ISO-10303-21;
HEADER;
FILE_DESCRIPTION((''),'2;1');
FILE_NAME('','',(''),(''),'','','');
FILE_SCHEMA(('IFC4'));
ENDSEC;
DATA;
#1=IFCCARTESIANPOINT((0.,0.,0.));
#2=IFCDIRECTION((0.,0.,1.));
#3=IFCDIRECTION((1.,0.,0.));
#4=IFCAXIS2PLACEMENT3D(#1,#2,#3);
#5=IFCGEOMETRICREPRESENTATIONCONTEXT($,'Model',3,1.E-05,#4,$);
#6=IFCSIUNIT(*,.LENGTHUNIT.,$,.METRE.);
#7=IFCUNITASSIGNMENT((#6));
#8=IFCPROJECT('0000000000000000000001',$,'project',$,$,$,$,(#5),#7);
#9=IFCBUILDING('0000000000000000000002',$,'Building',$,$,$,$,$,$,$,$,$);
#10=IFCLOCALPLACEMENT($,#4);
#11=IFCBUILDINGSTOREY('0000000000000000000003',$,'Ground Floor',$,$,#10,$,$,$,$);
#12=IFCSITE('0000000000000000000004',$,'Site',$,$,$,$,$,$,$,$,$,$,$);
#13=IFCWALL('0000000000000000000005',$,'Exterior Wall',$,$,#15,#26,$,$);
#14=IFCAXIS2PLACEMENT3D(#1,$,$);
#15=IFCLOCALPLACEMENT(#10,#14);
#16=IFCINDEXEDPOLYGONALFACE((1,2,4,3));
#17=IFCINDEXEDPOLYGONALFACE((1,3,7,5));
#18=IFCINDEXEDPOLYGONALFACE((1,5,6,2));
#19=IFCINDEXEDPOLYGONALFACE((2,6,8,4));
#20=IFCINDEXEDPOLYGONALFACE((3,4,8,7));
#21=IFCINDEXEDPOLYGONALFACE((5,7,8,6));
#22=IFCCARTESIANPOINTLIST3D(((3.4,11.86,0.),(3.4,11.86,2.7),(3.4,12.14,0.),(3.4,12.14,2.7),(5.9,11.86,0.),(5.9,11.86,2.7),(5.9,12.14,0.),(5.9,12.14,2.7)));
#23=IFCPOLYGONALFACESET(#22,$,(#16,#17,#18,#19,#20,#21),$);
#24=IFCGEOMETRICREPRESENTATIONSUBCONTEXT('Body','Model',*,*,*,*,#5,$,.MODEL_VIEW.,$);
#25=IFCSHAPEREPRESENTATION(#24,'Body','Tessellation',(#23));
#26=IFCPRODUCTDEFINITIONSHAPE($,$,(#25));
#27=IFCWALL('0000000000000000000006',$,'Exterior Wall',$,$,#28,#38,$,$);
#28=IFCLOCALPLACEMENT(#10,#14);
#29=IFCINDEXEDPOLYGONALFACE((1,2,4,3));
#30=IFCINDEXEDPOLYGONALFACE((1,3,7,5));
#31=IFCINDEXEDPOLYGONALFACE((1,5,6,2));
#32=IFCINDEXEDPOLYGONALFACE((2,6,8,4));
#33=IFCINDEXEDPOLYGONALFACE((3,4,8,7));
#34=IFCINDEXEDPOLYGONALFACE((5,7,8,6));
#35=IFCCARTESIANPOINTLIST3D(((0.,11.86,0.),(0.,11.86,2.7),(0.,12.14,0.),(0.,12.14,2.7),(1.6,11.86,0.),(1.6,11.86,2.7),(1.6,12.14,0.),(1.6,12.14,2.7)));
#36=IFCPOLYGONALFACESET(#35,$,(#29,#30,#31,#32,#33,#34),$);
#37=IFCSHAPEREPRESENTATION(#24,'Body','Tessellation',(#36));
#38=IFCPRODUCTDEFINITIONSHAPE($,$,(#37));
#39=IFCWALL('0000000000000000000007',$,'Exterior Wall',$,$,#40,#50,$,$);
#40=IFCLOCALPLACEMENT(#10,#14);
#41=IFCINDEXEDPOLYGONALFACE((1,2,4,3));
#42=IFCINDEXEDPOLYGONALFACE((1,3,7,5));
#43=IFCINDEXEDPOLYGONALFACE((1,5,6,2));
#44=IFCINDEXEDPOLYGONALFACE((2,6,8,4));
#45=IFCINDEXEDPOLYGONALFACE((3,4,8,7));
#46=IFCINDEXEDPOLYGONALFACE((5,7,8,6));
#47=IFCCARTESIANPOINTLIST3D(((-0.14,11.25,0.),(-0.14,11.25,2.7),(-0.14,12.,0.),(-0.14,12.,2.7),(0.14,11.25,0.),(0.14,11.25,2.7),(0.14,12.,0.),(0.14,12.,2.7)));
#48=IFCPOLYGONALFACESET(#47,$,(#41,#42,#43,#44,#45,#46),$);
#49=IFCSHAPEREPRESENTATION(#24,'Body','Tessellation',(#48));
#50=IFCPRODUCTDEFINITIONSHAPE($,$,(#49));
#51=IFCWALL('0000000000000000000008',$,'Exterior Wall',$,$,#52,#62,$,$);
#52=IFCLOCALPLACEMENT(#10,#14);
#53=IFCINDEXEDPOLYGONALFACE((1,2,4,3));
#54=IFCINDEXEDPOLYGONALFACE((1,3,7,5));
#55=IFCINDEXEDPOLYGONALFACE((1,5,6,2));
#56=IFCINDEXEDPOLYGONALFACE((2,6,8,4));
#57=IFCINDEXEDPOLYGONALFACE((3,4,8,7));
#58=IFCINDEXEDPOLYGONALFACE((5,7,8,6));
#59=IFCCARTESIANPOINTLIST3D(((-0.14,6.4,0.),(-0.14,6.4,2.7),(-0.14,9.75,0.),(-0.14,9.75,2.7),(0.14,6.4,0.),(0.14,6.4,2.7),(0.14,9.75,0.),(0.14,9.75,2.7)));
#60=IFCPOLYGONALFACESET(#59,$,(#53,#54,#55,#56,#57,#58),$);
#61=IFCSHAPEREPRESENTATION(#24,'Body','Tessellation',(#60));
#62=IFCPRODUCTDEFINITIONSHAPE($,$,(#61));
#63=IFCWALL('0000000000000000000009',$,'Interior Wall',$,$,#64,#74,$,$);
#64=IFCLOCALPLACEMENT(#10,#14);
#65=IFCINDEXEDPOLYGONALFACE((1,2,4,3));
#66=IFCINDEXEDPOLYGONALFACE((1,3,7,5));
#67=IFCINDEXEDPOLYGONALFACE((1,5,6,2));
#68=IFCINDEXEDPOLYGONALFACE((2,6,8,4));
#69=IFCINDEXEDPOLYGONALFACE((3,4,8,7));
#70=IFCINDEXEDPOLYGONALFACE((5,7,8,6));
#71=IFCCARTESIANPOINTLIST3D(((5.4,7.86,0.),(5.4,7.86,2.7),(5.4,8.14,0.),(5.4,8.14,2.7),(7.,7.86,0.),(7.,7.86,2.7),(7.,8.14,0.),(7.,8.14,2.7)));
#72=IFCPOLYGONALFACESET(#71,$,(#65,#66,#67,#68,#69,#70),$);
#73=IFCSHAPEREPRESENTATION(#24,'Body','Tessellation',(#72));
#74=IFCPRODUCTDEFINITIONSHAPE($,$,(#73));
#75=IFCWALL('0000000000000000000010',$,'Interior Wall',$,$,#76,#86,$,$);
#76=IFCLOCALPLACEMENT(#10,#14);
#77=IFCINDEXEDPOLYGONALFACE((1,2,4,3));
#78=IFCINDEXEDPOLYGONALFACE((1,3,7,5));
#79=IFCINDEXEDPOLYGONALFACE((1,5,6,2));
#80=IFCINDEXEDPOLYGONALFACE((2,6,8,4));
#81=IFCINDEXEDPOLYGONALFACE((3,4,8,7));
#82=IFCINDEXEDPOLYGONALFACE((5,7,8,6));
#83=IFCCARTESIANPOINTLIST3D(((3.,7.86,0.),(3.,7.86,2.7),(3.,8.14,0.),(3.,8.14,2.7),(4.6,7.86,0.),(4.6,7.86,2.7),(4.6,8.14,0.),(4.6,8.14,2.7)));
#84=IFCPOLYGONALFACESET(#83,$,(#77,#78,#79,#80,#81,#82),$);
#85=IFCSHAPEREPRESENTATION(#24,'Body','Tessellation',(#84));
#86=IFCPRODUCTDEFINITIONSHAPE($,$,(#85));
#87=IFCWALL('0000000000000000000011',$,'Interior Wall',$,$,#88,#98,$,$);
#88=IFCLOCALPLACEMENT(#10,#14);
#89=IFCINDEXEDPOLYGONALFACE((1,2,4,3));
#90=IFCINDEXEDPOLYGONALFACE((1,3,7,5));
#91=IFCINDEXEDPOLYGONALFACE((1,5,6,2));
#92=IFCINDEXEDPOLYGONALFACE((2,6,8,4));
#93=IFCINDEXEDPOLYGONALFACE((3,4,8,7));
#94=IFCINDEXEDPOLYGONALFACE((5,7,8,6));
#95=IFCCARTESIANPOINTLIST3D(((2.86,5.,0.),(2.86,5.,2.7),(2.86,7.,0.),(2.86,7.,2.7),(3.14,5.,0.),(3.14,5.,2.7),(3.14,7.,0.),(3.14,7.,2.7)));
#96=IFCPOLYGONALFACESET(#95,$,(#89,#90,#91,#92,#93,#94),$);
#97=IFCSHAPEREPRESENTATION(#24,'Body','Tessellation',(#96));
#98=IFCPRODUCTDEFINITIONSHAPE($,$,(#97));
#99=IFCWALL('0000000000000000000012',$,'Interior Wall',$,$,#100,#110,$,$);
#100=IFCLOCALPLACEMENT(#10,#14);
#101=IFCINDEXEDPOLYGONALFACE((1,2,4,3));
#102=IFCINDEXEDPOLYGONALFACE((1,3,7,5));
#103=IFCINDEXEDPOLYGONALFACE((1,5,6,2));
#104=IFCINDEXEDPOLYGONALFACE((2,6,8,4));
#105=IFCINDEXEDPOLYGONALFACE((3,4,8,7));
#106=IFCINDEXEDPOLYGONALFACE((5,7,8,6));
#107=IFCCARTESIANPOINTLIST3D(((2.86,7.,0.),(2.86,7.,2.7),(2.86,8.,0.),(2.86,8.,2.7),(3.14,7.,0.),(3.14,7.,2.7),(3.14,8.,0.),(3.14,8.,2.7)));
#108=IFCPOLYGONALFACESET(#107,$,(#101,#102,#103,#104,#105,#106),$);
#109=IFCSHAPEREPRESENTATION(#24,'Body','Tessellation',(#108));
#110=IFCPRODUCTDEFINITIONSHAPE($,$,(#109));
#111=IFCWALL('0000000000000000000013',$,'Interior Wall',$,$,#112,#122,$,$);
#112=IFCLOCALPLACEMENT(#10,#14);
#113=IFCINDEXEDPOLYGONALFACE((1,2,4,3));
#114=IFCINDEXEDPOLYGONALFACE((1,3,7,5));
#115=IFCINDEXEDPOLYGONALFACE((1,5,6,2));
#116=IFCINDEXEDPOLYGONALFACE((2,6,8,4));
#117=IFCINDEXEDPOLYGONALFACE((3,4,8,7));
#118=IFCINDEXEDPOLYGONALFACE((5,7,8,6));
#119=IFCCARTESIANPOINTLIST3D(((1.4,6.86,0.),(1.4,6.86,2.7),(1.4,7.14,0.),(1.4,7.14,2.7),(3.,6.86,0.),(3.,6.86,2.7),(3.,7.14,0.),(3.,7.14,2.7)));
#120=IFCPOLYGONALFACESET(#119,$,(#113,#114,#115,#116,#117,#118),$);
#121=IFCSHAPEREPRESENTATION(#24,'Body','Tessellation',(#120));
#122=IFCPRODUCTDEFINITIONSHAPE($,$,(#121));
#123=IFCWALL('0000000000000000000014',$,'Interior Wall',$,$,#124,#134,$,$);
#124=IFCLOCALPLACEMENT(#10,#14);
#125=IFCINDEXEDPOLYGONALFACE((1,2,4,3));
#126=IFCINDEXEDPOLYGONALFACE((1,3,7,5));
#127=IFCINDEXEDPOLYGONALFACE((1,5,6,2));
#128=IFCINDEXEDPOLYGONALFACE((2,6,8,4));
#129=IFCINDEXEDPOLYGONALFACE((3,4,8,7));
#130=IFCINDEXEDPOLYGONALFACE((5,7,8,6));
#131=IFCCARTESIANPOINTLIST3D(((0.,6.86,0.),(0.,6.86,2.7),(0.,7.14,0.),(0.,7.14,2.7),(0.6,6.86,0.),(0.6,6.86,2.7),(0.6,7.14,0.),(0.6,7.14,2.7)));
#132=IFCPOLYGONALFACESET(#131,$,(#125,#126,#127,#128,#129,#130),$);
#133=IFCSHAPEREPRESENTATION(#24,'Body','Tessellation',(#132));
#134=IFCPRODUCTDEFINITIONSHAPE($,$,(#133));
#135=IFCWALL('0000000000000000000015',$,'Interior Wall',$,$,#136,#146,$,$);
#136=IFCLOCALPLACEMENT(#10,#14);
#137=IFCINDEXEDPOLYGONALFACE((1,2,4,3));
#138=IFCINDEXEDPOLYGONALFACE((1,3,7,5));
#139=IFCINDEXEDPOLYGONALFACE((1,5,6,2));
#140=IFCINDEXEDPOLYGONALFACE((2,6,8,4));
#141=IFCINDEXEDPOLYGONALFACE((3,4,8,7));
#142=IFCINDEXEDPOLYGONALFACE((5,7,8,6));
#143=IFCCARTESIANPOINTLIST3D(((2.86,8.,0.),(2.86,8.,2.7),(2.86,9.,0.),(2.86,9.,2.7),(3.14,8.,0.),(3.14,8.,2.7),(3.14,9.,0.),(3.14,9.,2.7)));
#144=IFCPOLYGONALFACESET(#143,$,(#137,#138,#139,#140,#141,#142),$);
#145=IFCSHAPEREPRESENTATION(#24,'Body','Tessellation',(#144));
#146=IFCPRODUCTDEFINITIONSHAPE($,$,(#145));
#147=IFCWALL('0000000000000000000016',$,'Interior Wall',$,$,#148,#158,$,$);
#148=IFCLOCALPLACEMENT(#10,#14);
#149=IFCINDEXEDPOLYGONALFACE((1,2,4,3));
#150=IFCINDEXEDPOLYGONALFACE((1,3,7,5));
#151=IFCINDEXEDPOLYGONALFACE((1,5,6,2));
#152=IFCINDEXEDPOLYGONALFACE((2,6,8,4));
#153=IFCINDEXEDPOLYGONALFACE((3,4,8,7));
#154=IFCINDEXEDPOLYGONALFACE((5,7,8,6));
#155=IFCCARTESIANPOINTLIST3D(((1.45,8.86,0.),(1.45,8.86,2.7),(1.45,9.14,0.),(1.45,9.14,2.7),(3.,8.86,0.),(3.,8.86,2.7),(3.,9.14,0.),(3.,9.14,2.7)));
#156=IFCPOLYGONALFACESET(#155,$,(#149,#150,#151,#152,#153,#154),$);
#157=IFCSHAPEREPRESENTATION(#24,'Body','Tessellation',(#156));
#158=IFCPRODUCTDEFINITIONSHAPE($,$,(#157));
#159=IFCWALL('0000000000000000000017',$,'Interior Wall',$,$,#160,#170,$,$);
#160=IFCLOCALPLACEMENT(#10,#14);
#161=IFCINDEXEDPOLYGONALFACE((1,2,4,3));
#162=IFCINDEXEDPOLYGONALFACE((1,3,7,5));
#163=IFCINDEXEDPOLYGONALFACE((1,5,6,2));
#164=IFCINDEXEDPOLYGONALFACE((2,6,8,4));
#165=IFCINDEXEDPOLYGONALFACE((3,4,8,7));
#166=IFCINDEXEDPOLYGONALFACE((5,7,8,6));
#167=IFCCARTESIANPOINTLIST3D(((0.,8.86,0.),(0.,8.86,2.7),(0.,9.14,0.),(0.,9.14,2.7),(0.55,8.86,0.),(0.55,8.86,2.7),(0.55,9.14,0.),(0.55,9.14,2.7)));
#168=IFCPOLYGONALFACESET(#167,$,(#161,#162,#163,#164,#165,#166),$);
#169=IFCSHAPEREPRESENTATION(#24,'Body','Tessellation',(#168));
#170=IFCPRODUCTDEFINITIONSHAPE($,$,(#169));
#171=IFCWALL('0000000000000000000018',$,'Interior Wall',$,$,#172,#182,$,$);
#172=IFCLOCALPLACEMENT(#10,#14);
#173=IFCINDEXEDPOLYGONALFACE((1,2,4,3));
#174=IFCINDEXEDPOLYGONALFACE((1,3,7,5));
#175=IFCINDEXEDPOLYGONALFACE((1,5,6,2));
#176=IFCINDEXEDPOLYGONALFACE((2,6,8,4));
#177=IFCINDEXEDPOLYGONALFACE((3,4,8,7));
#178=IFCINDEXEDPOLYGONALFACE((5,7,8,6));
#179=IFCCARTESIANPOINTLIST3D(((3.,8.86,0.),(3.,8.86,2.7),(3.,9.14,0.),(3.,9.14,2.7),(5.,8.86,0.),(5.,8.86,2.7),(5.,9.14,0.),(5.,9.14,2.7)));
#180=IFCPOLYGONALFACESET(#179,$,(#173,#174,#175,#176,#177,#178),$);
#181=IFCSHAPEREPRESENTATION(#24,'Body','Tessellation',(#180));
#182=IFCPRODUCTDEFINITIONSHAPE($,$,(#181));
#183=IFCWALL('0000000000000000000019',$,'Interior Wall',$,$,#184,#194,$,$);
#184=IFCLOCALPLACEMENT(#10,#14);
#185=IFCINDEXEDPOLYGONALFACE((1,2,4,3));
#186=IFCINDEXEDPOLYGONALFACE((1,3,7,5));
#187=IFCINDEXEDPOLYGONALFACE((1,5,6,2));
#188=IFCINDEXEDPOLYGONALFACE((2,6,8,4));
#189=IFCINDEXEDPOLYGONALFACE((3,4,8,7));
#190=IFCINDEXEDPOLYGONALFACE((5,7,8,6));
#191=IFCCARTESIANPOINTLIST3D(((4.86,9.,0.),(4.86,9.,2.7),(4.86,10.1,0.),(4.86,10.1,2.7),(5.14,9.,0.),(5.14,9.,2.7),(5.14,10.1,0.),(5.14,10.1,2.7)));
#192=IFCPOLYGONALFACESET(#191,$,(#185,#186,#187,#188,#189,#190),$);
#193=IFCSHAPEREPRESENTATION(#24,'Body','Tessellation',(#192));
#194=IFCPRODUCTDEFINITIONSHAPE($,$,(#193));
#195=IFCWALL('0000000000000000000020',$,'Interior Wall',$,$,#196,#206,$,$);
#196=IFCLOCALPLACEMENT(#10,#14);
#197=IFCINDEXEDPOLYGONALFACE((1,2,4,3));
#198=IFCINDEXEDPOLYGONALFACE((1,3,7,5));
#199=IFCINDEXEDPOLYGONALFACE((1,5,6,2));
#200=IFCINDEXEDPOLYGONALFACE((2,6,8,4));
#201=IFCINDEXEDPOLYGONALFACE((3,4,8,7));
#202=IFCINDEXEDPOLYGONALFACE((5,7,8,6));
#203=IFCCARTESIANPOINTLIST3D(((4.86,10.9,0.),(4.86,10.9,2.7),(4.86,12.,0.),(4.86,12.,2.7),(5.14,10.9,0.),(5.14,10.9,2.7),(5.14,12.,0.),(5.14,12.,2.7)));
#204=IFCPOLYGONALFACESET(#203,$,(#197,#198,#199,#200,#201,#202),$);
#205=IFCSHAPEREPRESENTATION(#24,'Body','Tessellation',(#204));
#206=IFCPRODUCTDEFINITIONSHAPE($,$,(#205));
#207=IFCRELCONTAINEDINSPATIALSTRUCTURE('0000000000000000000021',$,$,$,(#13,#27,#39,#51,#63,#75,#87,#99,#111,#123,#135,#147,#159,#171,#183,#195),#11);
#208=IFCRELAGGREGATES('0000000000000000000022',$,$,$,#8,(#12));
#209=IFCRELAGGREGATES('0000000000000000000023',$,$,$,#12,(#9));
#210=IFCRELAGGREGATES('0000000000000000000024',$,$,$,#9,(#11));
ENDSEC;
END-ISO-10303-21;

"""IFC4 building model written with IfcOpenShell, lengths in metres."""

from ifc_helpers import new_model, si_unit, frame, origin_with_axes, place, context, subcontext, project, spatial, indexed_curve, outline, extrude, element, save


model = new_model("IFC4")

# Units and contexts
model_context = context("Model", 3, precision=1e-05, world=origin_with_axes())
body_context = subcontext(model_context, "Body", "Model", "MODEL_VIEW")
ifc_project = project(units=[si_unit("LENGTHUNIT", "METRE")], contexts=[model_context])

# Site, building, storey
site = spatial("IfcSite", under=ifc_project, Name="Site")
building = spatial("IfcBuilding", under=site, Name="Building")
storey_placement = place(None, origin_with_axes())
storey = spatial("IfcBuildingStorey", under=building, at=storey_placement, Name="Ground Floor")

# Walls
wall_1_placement = place(storey_placement, frame((5.9, 12.0, 0.0), z_axis=(0.0, 0.0, 1.0), x_axis=(-1.0, 0.0, 0.0)))
element("IfcWall", 1, at=wall_1_placement, inside=storey, Name="Exterior Wall", context=body_context, shape_type="SweptSolid", body=[
    extrude(outline(indexed_curve([(0.0, 0.0), (0.0, 0.28), (2.5, 0.28), (2.5, 0.0), (0.0, 0.0)], self_intersect=False)), frame((0.0, -0.14, 0.0), z_axis=(0.0, 0.0, 1.0), x_axis=(1.0, 0.0, 0.0)), (0.0, 0.0, 1.0), 2.7),
])
wall_2_placement = place(storey_placement, frame((1.6, 12.0, 0.0), z_axis=(0.0, 0.0, 1.0), x_axis=(-1.0, 0.0, 0.0)))
element("IfcWall", 2, at=wall_2_placement, inside=storey, Name="Exterior Wall", context=body_context, shape_type="SweptSolid", body=[
    extrude(outline(indexed_curve([(0.0, 0.0), (0.0, 0.28), (1.6, 0.28), (1.6, 0.0), (0.0, 0.0)], self_intersect=False)), frame((0.0, -0.14, 0.0), z_axis=(0.0, 0.0, 1.0), x_axis=(1.0, 0.0, 0.0)), (0.0, 0.0, 1.0), 2.7),
])
wall_3_placement = place(storey_placement, frame((0.0, 12.0, 0.0), z_axis=(0.0, 0.0, 1.0), x_axis=(0.0, -1.0, 0.0)))
element("IfcWall", 3, at=wall_3_placement, inside=storey, Name="Exterior Wall", context=body_context, shape_type="SweptSolid", body=[
    extrude(outline(indexed_curve([(0.0, 0.0), (0.0, 0.28), (0.75, 0.28), (0.75, 0.0), (0.0, 0.0)], self_intersect=False)), frame((0.0, -0.14, 0.0), z_axis=(0.0, 0.0, 1.0), x_axis=(1.0, 0.0, 0.0)), (0.0, 0.0, 1.0), 2.7),
])
wall_4_placement = place(storey_placement, frame((0.0, 9.75, 0.0), z_axis=(0.0, 0.0, 1.0), x_axis=(0.0, -1.0, 0.0)))
element("IfcWall", 4, at=wall_4_placement, inside=storey, Name="Exterior Wall", context=body_context, shape_type="SweptSolid", body=[
    extrude(outline(indexed_curve([(0.0, 0.0), (0.0, 0.28), (3.35, 0.28), (3.35, 0.0), (0.0, 0.0)], self_intersect=False)), frame((0.0, -0.14, 0.0), z_axis=(0.0, 0.0, 1.0), x_axis=(1.0, 0.0, 0.0)), (0.0, 0.0, 1.0), 2.7),
])
for number, where, z_axis, x_axis, name in (
    (5, (7.0, 8.0, 0.0), (0.0, 0.0, 1.0), (-1.0, 0.0, 0.0), "Interior Wall"),
    (6, (4.6, 8.0, 0.0), (0.0, 0.0, 1.0), (-1.0, 0.0, 0.0), "Interior Wall"),
):
    element("IfcWall", number, at=place(storey_placement, frame(where, z_axis=z_axis, x_axis=x_axis)), inside=storey, Name=name, context=body_context, shape_type="SweptSolid", body=[
        extrude(outline(indexed_curve([(0.0, 0.0), (0.0, 0.28), (1.6, 0.28), (1.6, 0.0), (0.0, 0.0)], self_intersect=False)), frame((0.0, -0.14, 0.0), z_axis=(0.0, 0.0, 1.0), x_axis=(1.0, 0.0, 0.0)), (0.0, 0.0, 1.0), 2.7),
    ])
wall_5_placement = place(storey_placement, frame((3.0, 7.0, 0.0), z_axis=(0.0, 0.0, 1.0), x_axis=(0.0, -1.0, 0.0)))
element("IfcWall", 7, at=wall_5_placement, inside=storey, Name="Interior Wall", context=body_context, shape_type="SweptSolid", body=[
    extrude(outline(indexed_curve([(0.0, 0.0), (0.0, 0.28), (2.0, 0.28), (2.0, 0.0), (0.0, 0.0)], self_intersect=False)), frame((0.0, -0.14, 0.0), z_axis=(0.0, 0.0, 1.0), x_axis=(1.0, 0.0, 0.0)), (0.0, 0.0, 1.0), 2.7),
])
wall_6_placement = place(storey_placement, frame((3.0, 8.0, 0.0), z_axis=(0.0, 0.0, 1.0), x_axis=(0.0, -1.0, 0.0)))
element("IfcWall", 8, at=wall_6_placement, inside=storey, Name="Interior Wall", context=body_context, shape_type="SweptSolid", body=[
    extrude(outline(indexed_curve([(0.0, 0.0), (0.0, 0.28), (1.0, 0.28), (1.0, 0.0), (0.0, 0.0)], self_intersect=False)), frame((0.0, -0.14, 0.0), z_axis=(0.0, 0.0, 1.0), x_axis=(1.0, 0.0, 0.0)), (0.0, 0.0, 1.0), 2.7),
])
wall_7_placement = place(storey_placement, frame((3.0, 7.0, 0.0), z_axis=(0.0, 0.0, 1.0), x_axis=(-1.0, 0.0, 0.0)))
element("IfcWall", 9, at=wall_7_placement, inside=storey, Name="Interior Wall", context=body_context, shape_type="SweptSolid", body=[
    extrude(outline(indexed_curve([(0.0, 0.0), (0.0, 0.28), (1.6, 0.28), (1.6, 0.0), (0.0, 0.0)], self_intersect=False)), frame((0.0, -0.14, 0.0), z_axis=(0.0, 0.0, 1.0), x_axis=(1.0, 0.0, 0.0)), (0.0, 0.0, 1.0), 2.7),
])
wall_8_placement = place(storey_placement, frame((0.6, 7.0, 0.0), z_axis=(0.0, 0.0, 1.0), x_axis=(-1.0, 0.0, 0.0)))
element("IfcWall", 10, at=wall_8_placement, inside=storey, Name="Interior Wall", context=body_context, shape_type="SweptSolid", body=[
    extrude(outline(indexed_curve([(0.0, 0.0), (0.0, 0.28), (0.6, 0.28), (0.6, 0.0), (0.0, 0.0)], self_intersect=False)), frame((0.0, -0.14, 0.0), z_axis=(0.0, 0.0, 1.0), x_axis=(1.0, 0.0, 0.0)), (0.0, 0.0, 1.0), 2.7),
])
wall_9_placement = place(storey_placement, frame((3.0, 8.0, 0.0), z_axis=(0.0, 0.0, 1.0), x_axis=(0.0, 1.0, 0.0)))
element("IfcWall", 11, at=wall_9_placement, inside=storey, Name="Interior Wall", context=body_context, shape_type="SweptSolid", body=[
    extrude(outline(indexed_curve([(0.0, 0.0), (0.0, 0.28), (1.0, 0.28), (1.0, 0.0), (0.0, 0.0)], self_intersect=False)), frame((0.0, -0.14, 0.0), z_axis=(0.0, 0.0, 1.0), x_axis=(1.0, 0.0, 0.0)), (0.0, 0.0, 1.0), 2.7),
])
wall_10_placement = place(storey_placement, frame((3.0, 9.0, 0.0), z_axis=(0.0, 0.0, 1.0), x_axis=(-1.0, 0.0, 0.0)))
element("IfcWall", 12, at=wall_10_placement, inside=storey, Name="Interior Wall", context=body_context, shape_type="SweptSolid", body=[
    extrude(outline(indexed_curve([(0.0, 0.0), (0.0, 0.28), (1.55, 0.28), (1.55, 0.0), (0.0, 0.0)], self_intersect=False)), frame((0.0, -0.14, 0.0), z_axis=(0.0, 0.0, 1.0), x_axis=(1.0, 0.0, 0.0)), (0.0, 0.0, 1.0), 2.7),
])
wall_11_placement = place(storey_placement, frame((0.55, 9.0, 0.0), z_axis=(0.0, 0.0, 1.0), x_axis=(-1.0, 0.0, 0.0)))
element("IfcWall", 13, at=wall_11_placement, inside=storey, Name="Interior Wall", context=body_context, shape_type="SweptSolid", body=[
    extrude(outline(indexed_curve([(0.0, 0.0), (0.0, 0.28), (0.55, 0.28), (0.55, 0.0), (0.0, 0.0)], self_intersect=False)), frame((0.0, -0.14, 0.0), z_axis=(0.0, 0.0, 1.0), x_axis=(1.0, 0.0, 0.0)), (0.0, 0.0, 1.0), 2.7),
])
wall_12_placement = place(storey_placement, frame((3.0, 9.0, 0.0), z_axis=(0.0, 0.0, 1.0), x_axis=(1.0, 0.0, 0.0)))
element("IfcWall", 14, at=wall_12_placement, inside=storey, Name="Interior Wall", context=body_context, shape_type="SweptSolid", body=[
    extrude(outline(indexed_curve([(0.0, 0.0), (0.0, 0.28), (2.0, 0.28), (2.0, 0.0), (0.0, 0.0)], self_intersect=False)), frame((0.0, -0.14, 0.0), z_axis=(0.0, 0.0, 1.0), x_axis=(1.0, 0.0, 0.0)), (0.0, 0.0, 1.0), 2.7),
])
for number, where, z_axis, x_axis, name in (
    (15, (5.0, 9.0, 0.0), (0.0, 0.0, 1.0), (0.0, 1.0, 0.0), "Interior Wall"),
    (16, (5.0, 10.9, 0.0), (0.0, 0.0, 1.0), (0.0, 1.0, 0.0), "Interior Wall"),
):
    element("IfcWall", number, at=place(storey_placement, frame(where, z_axis=z_axis, x_axis=x_axis)), inside=storey, Name=name, context=body_context, shape_type="SweptSolid", body=[
        extrude(outline(indexed_curve([(0.0, 0.0), (0.0, 0.28), (1.1, 0.28), (1.1, 0.0), (0.0, 0.0)], self_intersect=False)), frame((0.0, -0.14, 0.0), z_axis=(0.0, 0.0, 1.0), x_axis=(1.0, 0.0, 0.0)), (0.0, 0.0, 1.0), 2.7),
    ])

save(model, "model.ifc")
